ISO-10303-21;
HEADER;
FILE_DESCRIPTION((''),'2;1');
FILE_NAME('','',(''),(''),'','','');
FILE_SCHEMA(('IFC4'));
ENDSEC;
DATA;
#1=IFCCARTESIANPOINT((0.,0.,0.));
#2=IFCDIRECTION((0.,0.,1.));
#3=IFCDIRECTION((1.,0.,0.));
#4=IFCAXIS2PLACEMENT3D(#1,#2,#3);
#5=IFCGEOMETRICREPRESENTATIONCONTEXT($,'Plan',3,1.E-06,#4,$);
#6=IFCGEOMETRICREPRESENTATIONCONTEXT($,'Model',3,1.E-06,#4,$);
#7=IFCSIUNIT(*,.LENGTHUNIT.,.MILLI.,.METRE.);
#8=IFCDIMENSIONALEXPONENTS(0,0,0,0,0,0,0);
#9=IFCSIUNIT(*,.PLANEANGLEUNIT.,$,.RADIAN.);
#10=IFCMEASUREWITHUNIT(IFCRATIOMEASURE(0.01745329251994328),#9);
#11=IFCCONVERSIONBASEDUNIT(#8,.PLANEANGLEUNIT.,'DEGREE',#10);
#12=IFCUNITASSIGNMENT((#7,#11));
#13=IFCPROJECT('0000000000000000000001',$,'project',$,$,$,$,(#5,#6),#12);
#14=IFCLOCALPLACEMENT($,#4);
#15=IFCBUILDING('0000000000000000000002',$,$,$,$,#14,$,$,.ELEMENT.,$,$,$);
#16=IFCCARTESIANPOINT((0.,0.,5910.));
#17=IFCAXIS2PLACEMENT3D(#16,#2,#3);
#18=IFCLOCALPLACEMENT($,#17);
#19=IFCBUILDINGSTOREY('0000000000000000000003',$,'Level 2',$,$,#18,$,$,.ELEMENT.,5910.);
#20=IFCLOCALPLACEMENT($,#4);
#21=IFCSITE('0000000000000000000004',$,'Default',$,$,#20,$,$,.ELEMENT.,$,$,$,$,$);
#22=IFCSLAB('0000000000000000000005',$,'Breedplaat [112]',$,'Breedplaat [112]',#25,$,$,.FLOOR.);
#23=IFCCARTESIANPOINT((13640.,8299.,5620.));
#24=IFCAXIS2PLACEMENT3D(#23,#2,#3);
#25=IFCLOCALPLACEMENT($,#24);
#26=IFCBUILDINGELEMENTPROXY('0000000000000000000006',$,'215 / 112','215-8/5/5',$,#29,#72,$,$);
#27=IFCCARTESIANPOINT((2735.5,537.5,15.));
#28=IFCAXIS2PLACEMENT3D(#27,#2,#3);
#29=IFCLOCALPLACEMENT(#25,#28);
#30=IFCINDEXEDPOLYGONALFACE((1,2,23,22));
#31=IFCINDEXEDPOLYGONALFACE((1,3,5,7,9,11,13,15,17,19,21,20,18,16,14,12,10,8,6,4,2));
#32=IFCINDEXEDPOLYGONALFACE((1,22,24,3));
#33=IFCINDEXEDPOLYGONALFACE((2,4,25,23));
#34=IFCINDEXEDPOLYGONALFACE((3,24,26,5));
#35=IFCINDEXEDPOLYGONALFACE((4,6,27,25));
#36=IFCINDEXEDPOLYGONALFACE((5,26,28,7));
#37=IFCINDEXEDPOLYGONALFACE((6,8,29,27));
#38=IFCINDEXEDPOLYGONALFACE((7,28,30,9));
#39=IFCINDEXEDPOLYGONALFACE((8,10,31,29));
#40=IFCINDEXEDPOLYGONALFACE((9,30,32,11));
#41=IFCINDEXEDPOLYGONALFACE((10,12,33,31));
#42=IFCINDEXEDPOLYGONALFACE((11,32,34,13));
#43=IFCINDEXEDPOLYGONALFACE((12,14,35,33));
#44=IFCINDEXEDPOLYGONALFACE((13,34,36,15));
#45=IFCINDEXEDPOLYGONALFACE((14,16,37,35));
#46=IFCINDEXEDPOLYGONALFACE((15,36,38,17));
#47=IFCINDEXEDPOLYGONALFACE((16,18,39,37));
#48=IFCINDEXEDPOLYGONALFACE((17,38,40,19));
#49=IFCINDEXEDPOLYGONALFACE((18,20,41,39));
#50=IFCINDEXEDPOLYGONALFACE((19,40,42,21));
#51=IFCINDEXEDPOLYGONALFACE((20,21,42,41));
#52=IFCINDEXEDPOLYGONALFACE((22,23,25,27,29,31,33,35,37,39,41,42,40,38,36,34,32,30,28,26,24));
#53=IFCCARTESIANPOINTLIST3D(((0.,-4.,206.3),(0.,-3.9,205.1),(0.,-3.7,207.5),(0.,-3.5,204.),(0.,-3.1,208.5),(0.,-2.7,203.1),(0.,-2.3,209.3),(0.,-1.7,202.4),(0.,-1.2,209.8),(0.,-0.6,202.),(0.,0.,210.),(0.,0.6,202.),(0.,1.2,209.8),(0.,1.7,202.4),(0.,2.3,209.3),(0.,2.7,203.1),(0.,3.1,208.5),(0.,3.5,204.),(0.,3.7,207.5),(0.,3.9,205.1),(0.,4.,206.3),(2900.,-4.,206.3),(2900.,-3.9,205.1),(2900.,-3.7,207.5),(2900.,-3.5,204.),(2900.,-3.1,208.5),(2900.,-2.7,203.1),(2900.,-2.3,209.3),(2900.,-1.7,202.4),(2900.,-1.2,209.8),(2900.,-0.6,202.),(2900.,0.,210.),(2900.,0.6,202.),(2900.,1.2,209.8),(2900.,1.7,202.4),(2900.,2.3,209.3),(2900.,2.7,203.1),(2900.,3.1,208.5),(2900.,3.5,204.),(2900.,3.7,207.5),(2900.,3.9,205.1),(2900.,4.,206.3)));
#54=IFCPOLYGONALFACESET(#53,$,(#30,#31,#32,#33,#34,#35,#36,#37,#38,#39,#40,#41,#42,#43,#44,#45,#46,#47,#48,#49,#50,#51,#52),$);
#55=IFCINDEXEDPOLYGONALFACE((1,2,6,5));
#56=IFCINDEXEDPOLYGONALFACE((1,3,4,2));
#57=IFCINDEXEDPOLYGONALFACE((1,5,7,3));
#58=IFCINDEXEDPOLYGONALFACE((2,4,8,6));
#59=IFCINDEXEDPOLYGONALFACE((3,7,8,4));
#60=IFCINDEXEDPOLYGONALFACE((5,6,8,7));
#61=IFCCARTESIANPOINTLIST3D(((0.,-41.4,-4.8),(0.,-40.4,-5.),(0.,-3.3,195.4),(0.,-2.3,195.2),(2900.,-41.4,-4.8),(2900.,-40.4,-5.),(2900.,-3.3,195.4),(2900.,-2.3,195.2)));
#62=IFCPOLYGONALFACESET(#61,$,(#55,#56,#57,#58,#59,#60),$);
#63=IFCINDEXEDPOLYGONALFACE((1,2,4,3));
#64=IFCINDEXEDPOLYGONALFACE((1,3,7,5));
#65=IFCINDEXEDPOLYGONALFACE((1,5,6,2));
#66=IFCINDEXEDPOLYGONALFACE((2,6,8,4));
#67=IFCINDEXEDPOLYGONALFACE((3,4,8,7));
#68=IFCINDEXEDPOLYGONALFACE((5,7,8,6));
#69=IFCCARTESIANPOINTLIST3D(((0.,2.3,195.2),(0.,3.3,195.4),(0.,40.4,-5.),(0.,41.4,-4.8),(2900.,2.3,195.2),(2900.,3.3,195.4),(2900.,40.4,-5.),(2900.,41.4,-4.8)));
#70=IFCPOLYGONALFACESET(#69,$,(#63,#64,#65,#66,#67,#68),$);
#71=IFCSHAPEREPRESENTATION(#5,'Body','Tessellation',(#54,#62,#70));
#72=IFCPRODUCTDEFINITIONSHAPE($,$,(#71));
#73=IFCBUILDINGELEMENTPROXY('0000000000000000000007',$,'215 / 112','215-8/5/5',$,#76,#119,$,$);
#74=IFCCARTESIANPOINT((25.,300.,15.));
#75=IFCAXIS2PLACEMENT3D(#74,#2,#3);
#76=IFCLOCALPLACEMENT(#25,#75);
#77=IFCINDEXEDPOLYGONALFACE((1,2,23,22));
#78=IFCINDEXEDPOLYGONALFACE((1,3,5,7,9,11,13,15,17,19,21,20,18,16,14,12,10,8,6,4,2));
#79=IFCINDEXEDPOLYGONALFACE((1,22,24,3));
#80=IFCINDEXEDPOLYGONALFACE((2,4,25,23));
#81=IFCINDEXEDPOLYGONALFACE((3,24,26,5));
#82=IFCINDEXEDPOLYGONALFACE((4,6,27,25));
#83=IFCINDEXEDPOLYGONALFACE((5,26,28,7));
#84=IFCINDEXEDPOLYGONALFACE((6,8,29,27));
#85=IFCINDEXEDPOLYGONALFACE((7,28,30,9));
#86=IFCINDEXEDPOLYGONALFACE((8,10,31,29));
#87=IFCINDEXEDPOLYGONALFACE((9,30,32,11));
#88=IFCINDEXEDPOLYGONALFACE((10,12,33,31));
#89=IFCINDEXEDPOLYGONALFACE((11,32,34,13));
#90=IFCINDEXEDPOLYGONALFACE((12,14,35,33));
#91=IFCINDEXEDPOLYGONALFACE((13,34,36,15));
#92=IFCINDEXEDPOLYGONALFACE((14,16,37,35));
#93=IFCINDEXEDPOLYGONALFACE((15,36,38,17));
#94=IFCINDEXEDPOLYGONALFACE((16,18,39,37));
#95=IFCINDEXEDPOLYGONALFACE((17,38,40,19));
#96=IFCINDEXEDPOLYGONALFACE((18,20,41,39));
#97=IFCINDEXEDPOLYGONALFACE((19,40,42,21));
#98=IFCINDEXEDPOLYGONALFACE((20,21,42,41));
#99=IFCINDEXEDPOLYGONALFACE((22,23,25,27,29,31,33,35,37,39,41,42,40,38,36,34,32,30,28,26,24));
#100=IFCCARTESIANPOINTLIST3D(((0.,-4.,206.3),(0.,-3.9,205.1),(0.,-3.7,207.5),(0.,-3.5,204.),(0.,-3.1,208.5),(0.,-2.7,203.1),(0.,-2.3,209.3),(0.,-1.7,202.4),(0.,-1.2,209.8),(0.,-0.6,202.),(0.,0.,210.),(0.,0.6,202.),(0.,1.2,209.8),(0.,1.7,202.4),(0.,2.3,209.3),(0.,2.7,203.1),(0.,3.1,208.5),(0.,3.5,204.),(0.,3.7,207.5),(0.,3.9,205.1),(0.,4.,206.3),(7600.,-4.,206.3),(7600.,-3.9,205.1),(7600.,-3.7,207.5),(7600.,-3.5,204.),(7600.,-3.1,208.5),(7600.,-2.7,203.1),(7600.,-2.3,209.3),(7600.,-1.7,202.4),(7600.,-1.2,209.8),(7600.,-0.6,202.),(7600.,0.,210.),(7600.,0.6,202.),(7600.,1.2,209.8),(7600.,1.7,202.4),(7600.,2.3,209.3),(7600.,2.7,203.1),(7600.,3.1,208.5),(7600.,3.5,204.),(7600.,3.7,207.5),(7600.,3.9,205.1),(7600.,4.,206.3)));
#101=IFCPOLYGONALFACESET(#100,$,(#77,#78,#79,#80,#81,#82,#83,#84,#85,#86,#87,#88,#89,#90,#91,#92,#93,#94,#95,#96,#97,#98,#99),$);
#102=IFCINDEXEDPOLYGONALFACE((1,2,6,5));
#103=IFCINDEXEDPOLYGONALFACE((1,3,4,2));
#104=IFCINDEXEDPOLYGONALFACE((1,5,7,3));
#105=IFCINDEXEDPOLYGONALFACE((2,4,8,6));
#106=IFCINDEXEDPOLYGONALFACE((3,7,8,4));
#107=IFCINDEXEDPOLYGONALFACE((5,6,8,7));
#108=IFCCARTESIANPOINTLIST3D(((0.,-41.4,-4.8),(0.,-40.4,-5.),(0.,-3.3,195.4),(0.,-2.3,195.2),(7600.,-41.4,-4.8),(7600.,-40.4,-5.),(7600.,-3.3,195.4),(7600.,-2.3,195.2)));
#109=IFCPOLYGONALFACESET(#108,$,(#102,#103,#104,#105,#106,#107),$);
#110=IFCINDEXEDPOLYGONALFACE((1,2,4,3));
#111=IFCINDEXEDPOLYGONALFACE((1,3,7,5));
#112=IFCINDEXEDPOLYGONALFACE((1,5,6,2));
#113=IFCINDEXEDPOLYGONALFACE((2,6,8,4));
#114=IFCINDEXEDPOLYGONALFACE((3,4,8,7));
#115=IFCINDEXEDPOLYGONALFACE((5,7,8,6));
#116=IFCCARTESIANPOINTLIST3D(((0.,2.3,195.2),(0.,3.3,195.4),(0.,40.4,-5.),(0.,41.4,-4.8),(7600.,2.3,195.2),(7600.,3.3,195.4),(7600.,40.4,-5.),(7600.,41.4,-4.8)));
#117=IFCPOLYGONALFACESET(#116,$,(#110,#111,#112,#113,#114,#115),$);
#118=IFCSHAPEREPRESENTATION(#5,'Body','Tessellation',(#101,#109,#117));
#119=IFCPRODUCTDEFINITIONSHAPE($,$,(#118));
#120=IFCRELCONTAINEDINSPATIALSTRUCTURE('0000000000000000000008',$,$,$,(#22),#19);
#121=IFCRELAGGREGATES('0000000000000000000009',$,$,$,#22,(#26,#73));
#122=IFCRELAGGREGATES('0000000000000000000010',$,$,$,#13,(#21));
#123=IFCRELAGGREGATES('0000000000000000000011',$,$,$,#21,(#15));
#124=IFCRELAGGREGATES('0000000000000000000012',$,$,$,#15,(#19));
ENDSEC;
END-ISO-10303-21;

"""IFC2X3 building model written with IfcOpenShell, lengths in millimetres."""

from ifc_helpers import new_model, entity, si_unit, converted_unit, frame, origin_with_axes, origin_2d_with_axis, place, context, project, spatial, rectangle, circle, extrude, element, aggregate, save


model = new_model("IFC2X3")

# Units and contexts
plan_context = context("Plan", 3, precision=1e-06, world=origin_with_axes())
model_context = context("Model", 3, precision=1e-06, world=origin_with_axes())
ifc_project = project(units=[si_unit("LENGTHUNIT", "METRE", prefix="MILLI"), converted_unit("PLANEANGLEUNIT", "DEGREE", entity("IfcRatioMeasure", 0.01745329251994328), si_unit("PLANEANGLEUNIT", "RADIAN"), dimensions=[0, 0, 0, 0, 0, 0, 0])], contexts=[plan_context, model_context])

# Site, building, storey
site_placement = place(None, origin_with_axes())
site = spatial("IfcSite", under=ifc_project, at=site_placement, Name="Default", CompositionType="ELEMENT")
building_placement = place(None, origin_with_axes())
building = spatial("IfcBuilding", under=site, at=building_placement, CompositionType="ELEMENT")
storey_placement = place(None, frame((0.0, 0.0, 5910.0), z_axis=(0.0, 0.0, 1.0), x_axis=(1.0, 0.0, 0.0)))
storey = spatial("IfcBuildingStorey", under=building, at=storey_placement, Name="Level 2", CompositionType="ELEMENT", Elevation=5910.0)

# Slab, building element proxies
slab_1_placement = place(None, frame((13640.0, 8299.0, 5620.0), z_axis=(0.0, 0.0, 1.0), x_axis=(1.0, 0.0, 0.0)))
slab_1 = element("IfcSlab", 1, at=slab_1_placement, inside=storey, Name="Breedplaat [112]", ObjectType="Breedplaat [112]", PredefinedType="FLOOR")
proxy_1_placement = place(slab_1_placement, frame((2735.5, 537.5, 15.0), z_axis=(0.0, 0.0, 1.0), x_axis=(1.0, 0.0, 0.0)))
proxy_1 = element("IfcBuildingElementProxy", 2, at=proxy_1_placement, Name="215 / 112", Description="215-8/5/5", context=plan_context, shape_type="SweptSolid", body=[
    extrude(circle(Radius=4.0, at=origin_2d_with_axis()), frame((0.0, 0.0, 206.0), z_axis=(1.0, 0.0, 0.0), x_axis=(0.0, 0.0, 1.0)), (0.0, 0.0, 1.0), 2900.0),
    extrude(rectangle(XDim=203.8, YDim=1.0, at=origin_2d_with_axis()), frame((0.0, -21.9, 95.2), z_axis=(1.0, 0.0, 0.0), x_axis=(0.0, 0.187112, 0.982339)), (0.0, 0.0, 1.0), 2900.0),
    extrude(rectangle(XDim=203.8, YDim=1.0, at=origin_2d_with_axis()), frame((0.0, 21.9, 95.2), z_axis=(1.0, 0.0, 0.0), x_axis=(0.0, -0.187112, 0.982339)), (0.0, 0.0, 1.0), 2900.0),
])
proxy_2_placement = place(slab_1_placement, frame((25.0, 300.0, 15.0), z_axis=(0.0, 0.0, 1.0), x_axis=(1.0, 0.0, 0.0)))
proxy_2 = element("IfcBuildingElementProxy", 3, at=proxy_2_placement, Name="215 / 112", Description="215-8/5/5", context=plan_context, shape_type="SweptSolid", body=[
    extrude(circle(Radius=4.0, at=origin_2d_with_axis()), frame((0.0, 0.0, 206.0), z_axis=(1.0, 0.0, 0.0), x_axis=(0.0, 0.0, 1.0)), (0.0, 0.0, 1.0), 7600.0),
    extrude(rectangle(XDim=203.8, YDim=1.0, at=origin_2d_with_axis()), frame((0.0, -21.9, 95.2), z_axis=(1.0, 0.0, 0.0), x_axis=(0.0, 0.187112, 0.982339)), (0.0, 0.0, 1.0), 7600.0),
    extrude(rectangle(XDim=203.8, YDim=1.0, at=origin_2d_with_axis()), frame((0.0, 21.9, 95.2), z_axis=(1.0, 0.0, 0.0), x_axis=(0.0, -0.187112, 0.982339)), (0.0, 0.0, 1.0), 7600.0),
])
aggregate(slab_1, [proxy_1, proxy_2])

save(model, "model.ifc")
